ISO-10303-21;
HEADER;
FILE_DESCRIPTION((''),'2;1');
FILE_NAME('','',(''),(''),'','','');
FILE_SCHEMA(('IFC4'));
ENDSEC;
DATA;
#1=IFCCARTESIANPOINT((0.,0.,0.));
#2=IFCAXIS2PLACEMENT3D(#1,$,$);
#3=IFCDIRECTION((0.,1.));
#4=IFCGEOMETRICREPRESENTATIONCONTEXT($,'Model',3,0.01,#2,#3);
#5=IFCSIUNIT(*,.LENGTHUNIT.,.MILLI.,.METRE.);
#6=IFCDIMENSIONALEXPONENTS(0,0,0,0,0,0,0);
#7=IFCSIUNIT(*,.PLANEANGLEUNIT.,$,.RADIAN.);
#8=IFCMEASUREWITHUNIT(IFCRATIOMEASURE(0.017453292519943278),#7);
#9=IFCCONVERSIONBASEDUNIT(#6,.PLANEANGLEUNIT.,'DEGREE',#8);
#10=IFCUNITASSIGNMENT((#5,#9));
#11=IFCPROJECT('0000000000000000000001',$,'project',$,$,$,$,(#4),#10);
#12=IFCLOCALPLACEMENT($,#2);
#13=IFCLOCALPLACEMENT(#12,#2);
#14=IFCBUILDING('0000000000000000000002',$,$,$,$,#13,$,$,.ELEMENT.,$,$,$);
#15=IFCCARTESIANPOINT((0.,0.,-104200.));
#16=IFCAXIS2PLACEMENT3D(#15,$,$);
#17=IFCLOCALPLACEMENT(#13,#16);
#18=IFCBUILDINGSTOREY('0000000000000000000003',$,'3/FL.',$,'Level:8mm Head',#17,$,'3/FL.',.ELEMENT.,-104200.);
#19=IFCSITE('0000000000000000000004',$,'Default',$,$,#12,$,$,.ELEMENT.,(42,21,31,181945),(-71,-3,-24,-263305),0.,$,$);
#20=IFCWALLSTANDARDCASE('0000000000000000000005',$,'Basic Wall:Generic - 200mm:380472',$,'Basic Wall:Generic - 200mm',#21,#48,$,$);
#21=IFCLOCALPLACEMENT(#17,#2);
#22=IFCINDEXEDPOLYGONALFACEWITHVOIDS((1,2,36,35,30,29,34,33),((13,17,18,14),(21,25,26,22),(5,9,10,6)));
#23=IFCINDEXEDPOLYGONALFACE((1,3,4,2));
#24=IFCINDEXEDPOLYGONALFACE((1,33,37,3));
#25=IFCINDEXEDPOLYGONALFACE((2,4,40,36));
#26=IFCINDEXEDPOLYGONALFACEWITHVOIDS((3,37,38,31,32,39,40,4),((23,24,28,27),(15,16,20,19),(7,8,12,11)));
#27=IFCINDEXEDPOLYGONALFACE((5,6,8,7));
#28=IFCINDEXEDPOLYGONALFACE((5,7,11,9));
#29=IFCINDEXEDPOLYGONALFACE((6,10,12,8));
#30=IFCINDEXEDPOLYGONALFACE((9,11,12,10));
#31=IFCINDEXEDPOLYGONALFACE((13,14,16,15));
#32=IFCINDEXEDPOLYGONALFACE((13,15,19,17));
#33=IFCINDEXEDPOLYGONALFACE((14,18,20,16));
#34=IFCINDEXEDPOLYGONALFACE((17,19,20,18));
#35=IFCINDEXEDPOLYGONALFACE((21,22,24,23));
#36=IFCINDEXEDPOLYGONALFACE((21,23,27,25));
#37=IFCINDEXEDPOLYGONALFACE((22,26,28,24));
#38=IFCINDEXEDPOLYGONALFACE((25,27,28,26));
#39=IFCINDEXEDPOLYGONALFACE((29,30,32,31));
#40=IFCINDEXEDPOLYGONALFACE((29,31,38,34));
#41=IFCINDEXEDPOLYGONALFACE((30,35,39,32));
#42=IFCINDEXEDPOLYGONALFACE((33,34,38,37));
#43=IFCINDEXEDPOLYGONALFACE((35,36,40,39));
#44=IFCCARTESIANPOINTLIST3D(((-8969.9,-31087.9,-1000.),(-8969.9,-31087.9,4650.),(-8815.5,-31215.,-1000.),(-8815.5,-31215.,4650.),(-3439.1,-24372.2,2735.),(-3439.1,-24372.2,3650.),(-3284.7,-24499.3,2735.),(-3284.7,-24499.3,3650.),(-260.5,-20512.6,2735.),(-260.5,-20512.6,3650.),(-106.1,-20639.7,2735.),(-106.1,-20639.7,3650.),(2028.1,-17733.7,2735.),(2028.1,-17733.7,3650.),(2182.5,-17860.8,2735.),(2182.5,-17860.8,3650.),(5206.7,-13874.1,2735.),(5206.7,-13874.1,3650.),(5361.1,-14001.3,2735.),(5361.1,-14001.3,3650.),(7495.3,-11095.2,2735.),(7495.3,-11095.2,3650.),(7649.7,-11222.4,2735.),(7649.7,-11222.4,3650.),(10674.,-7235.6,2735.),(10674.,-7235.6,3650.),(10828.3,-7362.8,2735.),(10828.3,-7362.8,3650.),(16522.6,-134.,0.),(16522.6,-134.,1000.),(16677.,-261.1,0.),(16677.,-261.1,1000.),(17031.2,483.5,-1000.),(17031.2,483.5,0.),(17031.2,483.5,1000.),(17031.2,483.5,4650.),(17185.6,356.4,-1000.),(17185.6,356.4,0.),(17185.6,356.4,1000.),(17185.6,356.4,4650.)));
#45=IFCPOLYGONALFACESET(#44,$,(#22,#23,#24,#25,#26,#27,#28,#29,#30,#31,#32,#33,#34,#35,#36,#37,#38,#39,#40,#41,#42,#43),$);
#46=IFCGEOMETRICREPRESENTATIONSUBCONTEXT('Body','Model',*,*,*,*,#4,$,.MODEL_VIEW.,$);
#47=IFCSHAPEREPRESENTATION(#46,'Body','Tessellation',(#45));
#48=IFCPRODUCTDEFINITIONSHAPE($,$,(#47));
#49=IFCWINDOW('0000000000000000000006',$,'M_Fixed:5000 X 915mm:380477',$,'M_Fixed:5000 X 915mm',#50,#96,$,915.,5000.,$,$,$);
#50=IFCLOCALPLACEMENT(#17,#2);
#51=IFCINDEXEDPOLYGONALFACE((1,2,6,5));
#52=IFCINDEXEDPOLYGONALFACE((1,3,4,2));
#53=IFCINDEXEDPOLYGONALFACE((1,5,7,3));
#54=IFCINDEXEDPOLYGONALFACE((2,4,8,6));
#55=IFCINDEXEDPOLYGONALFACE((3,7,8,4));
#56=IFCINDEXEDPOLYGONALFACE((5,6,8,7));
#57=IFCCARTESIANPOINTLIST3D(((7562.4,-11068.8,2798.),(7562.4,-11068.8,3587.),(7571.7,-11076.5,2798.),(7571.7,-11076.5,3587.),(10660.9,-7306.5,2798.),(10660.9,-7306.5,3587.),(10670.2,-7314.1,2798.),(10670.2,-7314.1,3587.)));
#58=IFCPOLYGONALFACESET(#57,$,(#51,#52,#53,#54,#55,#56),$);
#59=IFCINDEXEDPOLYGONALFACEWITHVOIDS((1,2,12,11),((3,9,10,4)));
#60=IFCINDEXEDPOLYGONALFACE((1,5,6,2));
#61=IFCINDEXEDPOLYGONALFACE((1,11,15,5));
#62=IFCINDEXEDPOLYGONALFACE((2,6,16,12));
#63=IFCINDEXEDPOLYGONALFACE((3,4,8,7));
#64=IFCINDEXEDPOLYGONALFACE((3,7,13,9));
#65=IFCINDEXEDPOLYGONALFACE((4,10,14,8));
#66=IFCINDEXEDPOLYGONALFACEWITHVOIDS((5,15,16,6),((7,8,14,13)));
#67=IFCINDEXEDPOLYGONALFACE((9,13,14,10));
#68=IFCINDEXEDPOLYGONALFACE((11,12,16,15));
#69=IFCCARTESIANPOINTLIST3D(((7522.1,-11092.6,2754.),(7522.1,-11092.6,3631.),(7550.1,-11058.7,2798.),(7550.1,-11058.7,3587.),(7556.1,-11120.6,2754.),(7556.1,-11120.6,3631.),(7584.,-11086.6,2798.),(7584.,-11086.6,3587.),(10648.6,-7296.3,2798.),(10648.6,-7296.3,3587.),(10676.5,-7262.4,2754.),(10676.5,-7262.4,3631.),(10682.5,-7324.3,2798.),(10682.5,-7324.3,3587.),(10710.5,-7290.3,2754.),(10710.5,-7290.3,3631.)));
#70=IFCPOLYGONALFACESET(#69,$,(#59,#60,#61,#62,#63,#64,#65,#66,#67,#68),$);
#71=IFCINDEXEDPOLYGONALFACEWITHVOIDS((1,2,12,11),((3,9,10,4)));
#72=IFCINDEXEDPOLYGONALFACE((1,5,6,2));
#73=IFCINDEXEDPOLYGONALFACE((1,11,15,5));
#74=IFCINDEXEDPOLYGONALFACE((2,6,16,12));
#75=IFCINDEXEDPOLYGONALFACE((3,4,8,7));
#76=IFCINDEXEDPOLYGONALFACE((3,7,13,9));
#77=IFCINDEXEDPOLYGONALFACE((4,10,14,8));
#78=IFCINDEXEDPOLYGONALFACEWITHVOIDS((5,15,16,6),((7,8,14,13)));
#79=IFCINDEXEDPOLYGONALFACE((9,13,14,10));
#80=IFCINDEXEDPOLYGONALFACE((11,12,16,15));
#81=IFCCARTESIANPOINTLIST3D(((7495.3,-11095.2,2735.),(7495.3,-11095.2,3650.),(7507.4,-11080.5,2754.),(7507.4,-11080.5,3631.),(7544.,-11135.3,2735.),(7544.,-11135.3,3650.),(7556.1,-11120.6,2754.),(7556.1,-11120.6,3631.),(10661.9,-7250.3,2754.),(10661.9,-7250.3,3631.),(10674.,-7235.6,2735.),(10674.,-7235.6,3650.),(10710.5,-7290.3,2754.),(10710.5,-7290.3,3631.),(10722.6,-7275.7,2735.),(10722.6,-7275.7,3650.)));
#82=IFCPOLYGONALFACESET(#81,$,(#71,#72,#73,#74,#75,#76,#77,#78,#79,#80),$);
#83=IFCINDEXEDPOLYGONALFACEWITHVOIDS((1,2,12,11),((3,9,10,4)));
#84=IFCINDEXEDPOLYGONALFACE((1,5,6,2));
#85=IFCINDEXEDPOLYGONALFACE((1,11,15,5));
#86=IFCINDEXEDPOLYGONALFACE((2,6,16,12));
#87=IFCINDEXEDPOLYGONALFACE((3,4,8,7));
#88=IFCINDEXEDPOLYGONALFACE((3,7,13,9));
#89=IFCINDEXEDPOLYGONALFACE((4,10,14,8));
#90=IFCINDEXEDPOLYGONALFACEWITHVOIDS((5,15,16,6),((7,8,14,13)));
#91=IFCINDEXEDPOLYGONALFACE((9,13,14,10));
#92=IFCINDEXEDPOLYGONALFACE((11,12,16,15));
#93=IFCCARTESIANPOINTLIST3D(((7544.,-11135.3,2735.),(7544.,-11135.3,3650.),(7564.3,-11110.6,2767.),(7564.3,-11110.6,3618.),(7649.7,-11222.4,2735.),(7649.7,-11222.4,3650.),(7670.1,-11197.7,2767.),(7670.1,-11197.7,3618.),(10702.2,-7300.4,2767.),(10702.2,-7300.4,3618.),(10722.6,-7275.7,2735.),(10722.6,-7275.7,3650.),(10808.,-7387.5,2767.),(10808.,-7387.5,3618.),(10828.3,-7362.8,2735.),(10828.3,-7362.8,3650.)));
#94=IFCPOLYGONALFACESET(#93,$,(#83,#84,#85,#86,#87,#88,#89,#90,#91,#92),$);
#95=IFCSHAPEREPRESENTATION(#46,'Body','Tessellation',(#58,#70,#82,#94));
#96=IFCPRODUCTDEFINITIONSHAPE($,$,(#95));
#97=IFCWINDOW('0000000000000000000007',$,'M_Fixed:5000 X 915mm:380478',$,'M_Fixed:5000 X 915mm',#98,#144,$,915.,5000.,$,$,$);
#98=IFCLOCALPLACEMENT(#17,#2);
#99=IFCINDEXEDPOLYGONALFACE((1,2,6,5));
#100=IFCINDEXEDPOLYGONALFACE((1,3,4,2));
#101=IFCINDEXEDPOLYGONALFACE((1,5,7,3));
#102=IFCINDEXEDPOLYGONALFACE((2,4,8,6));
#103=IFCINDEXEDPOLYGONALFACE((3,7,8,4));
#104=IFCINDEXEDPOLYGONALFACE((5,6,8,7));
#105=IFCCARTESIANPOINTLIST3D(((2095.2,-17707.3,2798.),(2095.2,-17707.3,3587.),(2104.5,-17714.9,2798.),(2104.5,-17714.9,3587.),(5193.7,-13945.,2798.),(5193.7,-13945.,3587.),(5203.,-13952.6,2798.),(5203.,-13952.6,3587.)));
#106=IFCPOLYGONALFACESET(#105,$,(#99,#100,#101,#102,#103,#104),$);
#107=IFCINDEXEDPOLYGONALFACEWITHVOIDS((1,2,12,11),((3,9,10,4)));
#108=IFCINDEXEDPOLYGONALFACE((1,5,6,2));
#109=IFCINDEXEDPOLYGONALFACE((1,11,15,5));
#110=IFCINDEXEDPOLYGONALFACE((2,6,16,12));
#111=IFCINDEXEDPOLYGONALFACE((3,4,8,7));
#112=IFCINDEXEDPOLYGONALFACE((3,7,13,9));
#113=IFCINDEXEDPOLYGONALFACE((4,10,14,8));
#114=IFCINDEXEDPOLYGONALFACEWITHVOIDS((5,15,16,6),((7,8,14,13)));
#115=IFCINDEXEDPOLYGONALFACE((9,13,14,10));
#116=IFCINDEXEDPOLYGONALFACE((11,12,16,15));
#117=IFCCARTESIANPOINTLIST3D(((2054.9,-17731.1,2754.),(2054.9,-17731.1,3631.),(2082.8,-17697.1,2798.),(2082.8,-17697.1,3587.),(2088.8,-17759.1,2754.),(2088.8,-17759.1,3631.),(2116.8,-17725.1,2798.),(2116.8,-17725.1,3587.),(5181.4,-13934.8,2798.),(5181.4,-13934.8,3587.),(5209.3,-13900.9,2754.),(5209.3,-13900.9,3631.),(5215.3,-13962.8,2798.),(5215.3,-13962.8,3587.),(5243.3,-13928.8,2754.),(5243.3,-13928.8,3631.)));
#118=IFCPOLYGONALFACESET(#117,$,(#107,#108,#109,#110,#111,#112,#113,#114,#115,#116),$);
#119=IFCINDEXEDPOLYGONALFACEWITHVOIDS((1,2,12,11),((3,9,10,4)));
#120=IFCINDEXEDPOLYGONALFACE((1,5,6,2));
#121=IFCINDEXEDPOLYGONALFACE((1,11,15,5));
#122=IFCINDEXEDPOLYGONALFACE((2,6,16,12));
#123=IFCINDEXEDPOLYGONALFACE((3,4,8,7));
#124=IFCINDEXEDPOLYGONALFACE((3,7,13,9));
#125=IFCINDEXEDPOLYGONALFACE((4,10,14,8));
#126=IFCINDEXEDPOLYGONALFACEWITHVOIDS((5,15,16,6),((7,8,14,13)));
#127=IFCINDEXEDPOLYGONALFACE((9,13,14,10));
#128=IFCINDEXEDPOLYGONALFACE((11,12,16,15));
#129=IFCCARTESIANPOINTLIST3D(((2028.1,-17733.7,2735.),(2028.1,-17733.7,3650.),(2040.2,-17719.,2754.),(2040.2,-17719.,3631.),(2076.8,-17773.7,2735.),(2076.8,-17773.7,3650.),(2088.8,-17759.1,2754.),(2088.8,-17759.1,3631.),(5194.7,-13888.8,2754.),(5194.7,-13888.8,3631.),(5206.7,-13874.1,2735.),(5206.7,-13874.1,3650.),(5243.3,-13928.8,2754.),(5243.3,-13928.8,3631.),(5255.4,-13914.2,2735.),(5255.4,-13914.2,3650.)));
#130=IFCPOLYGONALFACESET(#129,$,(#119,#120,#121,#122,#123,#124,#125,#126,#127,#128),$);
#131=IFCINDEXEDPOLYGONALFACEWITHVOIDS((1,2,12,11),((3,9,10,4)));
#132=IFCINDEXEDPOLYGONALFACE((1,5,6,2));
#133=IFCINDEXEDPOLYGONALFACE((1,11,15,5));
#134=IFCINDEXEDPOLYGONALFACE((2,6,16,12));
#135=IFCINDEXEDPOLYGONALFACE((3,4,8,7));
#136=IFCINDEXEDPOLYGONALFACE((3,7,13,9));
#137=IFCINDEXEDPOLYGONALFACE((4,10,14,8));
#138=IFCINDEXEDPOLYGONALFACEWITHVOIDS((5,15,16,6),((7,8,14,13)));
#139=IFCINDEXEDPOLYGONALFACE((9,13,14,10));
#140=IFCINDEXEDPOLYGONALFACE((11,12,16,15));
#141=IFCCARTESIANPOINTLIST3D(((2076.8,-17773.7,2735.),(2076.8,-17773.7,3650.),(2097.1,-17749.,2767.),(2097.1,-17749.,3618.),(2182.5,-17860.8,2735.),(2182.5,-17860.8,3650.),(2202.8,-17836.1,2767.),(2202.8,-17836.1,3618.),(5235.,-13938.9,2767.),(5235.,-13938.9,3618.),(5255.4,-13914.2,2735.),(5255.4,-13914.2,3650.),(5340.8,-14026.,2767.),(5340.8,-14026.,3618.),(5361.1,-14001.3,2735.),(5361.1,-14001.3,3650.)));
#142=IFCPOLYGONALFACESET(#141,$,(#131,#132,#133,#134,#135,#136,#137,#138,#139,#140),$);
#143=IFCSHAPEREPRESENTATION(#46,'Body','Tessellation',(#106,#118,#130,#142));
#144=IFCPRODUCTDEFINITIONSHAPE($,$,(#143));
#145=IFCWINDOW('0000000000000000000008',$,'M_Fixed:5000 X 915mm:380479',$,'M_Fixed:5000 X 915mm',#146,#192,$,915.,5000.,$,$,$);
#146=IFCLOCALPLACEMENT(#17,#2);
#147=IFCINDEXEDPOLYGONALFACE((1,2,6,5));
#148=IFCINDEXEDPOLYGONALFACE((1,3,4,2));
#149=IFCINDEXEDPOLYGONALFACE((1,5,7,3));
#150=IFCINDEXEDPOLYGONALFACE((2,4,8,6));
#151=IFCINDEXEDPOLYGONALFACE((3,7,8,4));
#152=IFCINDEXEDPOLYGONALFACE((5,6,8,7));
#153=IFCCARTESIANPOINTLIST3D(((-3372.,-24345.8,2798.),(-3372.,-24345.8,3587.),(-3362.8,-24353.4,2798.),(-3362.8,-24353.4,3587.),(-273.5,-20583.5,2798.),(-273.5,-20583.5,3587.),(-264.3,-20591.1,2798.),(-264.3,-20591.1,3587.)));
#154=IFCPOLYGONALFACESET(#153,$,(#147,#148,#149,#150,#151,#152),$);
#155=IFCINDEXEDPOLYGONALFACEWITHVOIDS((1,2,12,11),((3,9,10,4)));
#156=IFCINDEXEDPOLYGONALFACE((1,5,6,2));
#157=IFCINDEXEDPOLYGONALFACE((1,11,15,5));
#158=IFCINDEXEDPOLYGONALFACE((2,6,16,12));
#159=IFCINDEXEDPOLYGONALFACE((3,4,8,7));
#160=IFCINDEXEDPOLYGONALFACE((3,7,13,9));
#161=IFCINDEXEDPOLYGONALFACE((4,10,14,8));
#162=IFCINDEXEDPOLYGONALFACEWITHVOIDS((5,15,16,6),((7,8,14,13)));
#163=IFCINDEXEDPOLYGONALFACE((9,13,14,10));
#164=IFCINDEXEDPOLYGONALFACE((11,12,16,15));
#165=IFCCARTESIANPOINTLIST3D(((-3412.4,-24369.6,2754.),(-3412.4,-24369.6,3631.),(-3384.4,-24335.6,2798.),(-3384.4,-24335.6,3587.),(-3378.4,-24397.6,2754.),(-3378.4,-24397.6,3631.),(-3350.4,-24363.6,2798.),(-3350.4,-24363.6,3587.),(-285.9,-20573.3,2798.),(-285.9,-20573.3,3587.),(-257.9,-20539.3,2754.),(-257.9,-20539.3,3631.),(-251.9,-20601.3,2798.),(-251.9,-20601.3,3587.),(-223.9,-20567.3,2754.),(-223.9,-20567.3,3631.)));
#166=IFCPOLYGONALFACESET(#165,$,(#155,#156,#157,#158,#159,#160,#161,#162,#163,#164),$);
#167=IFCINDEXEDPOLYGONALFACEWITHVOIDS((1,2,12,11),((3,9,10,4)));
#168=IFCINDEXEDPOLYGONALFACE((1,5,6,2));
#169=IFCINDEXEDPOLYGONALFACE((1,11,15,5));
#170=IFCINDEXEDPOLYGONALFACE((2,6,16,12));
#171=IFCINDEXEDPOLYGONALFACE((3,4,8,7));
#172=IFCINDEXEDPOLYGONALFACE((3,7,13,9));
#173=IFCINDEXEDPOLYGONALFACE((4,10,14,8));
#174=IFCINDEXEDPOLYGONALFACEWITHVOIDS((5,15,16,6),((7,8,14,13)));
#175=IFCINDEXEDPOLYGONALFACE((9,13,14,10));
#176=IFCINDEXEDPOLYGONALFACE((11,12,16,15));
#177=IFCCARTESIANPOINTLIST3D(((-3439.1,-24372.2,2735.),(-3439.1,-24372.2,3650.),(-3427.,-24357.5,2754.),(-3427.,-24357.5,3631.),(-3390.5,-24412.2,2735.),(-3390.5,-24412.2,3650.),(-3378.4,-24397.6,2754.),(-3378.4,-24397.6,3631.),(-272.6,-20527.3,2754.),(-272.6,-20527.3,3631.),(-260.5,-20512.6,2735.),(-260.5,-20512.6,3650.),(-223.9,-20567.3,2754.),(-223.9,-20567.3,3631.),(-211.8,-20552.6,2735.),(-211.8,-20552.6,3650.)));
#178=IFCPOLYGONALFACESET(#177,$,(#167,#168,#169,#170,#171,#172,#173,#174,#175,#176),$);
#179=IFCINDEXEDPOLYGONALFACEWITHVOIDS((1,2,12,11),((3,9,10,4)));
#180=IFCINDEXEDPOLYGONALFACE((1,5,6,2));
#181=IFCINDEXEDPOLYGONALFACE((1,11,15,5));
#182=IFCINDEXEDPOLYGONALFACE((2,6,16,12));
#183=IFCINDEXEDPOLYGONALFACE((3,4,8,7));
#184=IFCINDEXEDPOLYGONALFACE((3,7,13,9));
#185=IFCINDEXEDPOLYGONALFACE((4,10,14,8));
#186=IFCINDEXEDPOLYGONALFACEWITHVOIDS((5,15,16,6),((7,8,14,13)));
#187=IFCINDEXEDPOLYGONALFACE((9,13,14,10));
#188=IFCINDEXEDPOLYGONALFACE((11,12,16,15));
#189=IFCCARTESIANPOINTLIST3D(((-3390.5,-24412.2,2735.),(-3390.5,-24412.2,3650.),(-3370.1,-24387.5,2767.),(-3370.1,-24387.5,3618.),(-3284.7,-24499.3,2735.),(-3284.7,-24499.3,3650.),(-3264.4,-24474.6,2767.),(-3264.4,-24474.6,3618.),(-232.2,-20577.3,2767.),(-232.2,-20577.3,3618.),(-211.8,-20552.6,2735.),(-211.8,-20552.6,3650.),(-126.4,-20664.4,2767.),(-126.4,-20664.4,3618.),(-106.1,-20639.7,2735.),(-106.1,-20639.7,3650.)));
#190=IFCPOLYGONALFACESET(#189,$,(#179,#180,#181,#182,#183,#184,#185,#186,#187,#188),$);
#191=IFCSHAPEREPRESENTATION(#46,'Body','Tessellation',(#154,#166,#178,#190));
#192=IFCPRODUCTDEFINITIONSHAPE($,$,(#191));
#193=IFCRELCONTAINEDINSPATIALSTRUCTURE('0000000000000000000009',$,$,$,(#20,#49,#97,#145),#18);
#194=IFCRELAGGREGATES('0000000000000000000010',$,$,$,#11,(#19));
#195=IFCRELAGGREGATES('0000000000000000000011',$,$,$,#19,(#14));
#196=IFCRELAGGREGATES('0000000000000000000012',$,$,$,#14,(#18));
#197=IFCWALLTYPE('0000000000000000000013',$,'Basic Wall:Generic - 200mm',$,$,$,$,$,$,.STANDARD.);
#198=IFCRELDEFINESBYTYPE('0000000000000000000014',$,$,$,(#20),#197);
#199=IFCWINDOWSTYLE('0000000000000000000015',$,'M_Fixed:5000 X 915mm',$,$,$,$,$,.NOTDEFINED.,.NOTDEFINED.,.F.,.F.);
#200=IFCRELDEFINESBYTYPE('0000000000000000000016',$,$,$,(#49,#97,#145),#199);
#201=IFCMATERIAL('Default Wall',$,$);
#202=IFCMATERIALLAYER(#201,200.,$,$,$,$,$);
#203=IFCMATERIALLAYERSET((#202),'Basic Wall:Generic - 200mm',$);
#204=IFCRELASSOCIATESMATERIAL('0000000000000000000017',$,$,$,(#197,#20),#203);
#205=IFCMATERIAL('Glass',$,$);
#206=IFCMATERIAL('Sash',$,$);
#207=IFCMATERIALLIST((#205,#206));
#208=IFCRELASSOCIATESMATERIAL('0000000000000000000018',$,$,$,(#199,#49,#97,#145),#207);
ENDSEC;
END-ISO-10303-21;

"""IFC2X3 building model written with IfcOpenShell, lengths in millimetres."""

from ifc_helpers import new_model, entity, si_unit, converted_unit, direction, frame, frame_2d, origin, place, context, subcontext, project, spatial, polyline, rectangle, outline, extrude, source, transform, mapped, material, material_list, layer, layer_set, layer_usage, type_object, type_shapes, element, fill, save


model = new_model("IFC2X3")

# Units and contexts
model_context = context("Model", 3, precision=0.01, world=origin(), true_north=direction((0.0, 1.0)))
body_context = subcontext(model_context, "Body", "Model", "MODEL_VIEW")
ifc_project = project(units=[si_unit("LENGTHUNIT", "METRE", prefix="MILLI"), converted_unit("PLANEANGLEUNIT", "DEGREE", entity("IfcRatioMeasure", 0.017453292519943278), si_unit("PLANEANGLEUNIT", "RADIAN"), dimensions=[0, 0, 0, 0, 0, 0, 0])], contexts=[model_context])

# Site, building, storey
site_placement = place(None, origin())
site = spatial("IfcSite", under=ifc_project, at=site_placement, Name="Default", CompositionType="ELEMENT", RefLatitude=(42, 21, 31, 181945), RefLongitude=(-71, -3, -24, -263305), RefElevation=0.0)
building_placement = place(site_placement, origin())
building = spatial("IfcBuilding", under=site, at=building_placement, CompositionType="ELEMENT")
storey_placement = place(building_placement, frame((0.0, 0.0, -104200.0)))
storey = spatial("IfcBuildingStorey", under=building, at=storey_placement, Name="3/FL.", ObjectType="Level:8mm Head", LongName="3/FL.", CompositionType="ELEMENT", Elevation=-104200.0)

# Shared definitions
ifc_material_1 = material(Name="Default Wall")
ifc_layer = layer(ifc_material_1, 200.0)
ifc_layer_set = layer_set([ifc_layer], Name="Basic Wall:Generic - 200mm")
ifc_layer_usage = layer_usage(ifc_layer_set, "AXIS2", "NEGATIVE", 100.0)
wall_type = type_object("IfcWallType", Name="Basic Wall:Generic - 200mm", PredefinedType="STANDARD", material=ifc_layer_set)

# Wall, openings, windows
wall_1_placement = place(storey_placement, frame((17108.4, 420.0, -1000.0), z_axis=(0.0, 0.0, 1.0), x_axis=(-0.635723, -0.771917, 0.0)))
wall_1 = element("IfcWallStandardCase", 1, at=wall_1_placement, inside=storey, type_object=wall_type, material=ifc_layer_usage, Name="Basic Wall:Generic - 200mm:380472", ObjectType="Basic Wall:Generic - 200mm", context=body_context, shape_type="SweptSolid", body=[
    extrude(rectangle(XDim=40900.0, YDim=200.0, at=frame_2d((20450.0, 0.0), x_axis=(-1.0, 0.0))), origin(), (0.0, 0.0, 1.0), 5650.0),
])
opening_1_placement = place(wall_1_placement, origin())
element("IfcOpeningElement", 2, at=opening_1_placement, cuts=wall_1, ObjectType="Opening", context=body_context, shape_type="SweptSolid", body=[
    extrude(rectangle(XDim=1000.0, YDim=1012.7, at=frame_2d((0.0, 0.0), x_axis=(1.0, 0.0))), frame((293.7, -183.3, 1500.0), z_axis=(0.0, 1.0, 0.0), x_axis=(0.0, 0.0, -1.0)), (0.0, 0.0, 1.0), 1010.1),
])
opening_2_placement = place(wall_1_placement, frame((15000.0, 100.0, 3735.0)))
opening_2 = element("IfcOpeningElement", 3, at=opening_2_placement, cuts=wall_1, ObjectType="Opening", context=body_context, shape_type="SweptSolid", body=[
    extrude(rectangle(XDim=915.0, YDim=5000.0, at=frame_2d((457.5, 2500.0), x_axis=(1.0, 0.0))), frame((0.0, 0.0, 0.0), z_axis=(0.0, -1.0, 0.0), x_axis=(0.0, 0.0, 1.0)), (0.0, 0.0, 1.0), 200.0),
])
opening_3_placement = place(wall_1_placement, frame((23600.0, 100.0, 3735.0)))
opening_3 = element("IfcOpeningElement", 4, at=opening_3_placement, cuts=wall_1, ObjectType="Opening", context=body_context, shape_type="SweptSolid", body=[
    extrude(rectangle(XDim=915.0, YDim=5000.0, at=frame_2d((457.5, 2500.0), x_axis=(1.0, 0.0))), frame((0.0, 0.0, 0.0), z_axis=(0.0, -1.0, 0.0), x_axis=(0.0, 0.0, 1.0)), (0.0, 0.0, 1.0), 200.0),
])
opening_4_placement = place(wall_1_placement, frame((32200.0, 100.0, 3735.0)))
opening_4 = element("IfcOpeningElement", 5, at=opening_4_placement, cuts=wall_1, ObjectType="Opening", context=body_context, shape_type="SweptSolid", body=[
    extrude(rectangle(XDim=915.0, YDim=5000.0, at=frame_2d((457.5, 2500.0), x_axis=(1.0, 0.0))), frame((0.0, 0.0, 0.0), z_axis=(0.0, -1.0, 0.0), x_axis=(0.0, 0.0, 1.0)), (0.0, 0.0, 1.0), 200.0),
])
ifc_material_2 = material(Name="Glass")
ifc_material_3 = material(Name="Sash")
ifc_material_list = material_list([ifc_material_2, ifc_material_3])
window_style_1 = type_object("IfcWindowStyle", Name="M_Fixed:5000 X 915mm", ConstructionType="NOTDEFINED", OperationType="NOTDEFINED", ParameterTakesPrecedence=False, Sizeable=False, material=ifc_material_list)
shared_shape_1 = source(origin(), body_context, "Body", "SweptSolid", [
    extrude(rectangle(XDim=12.0, YDim=4874.0, at=frame_2d((0.0, 0.0), x_axis=(1.0, 0.0))), frame((2500.0, 159.0, 63.0), z_axis=(0.0, 0.0, 1.0), x_axis=(0.0, -1.0, 0.0)), (0.0, 0.0, 1.0), 789.0),
    extrude(outline(polyline([(-2481.0, -438.5), (2481.0, -438.5), (2481.0, 438.5), (-2481.0, 438.5), (-2481.0, -438.5)]), holes=[polyline([(-2437.0, -394.5), (-2437.0, 394.5), (2437.0, 394.5), (2437.0, -394.5), (-2437.0, -394.5)])]), frame((2500.0, 137.0, 457.5), z_axis=(0.0, 1.0, 0.0), x_axis=(1.0, 0.0, 0.0)), (0.0, 0.0, 1.0), 44.0),
    extrude(outline(polyline([(-2500.0, -457.5), (2500.0, -457.5), (2500.0, 457.5), (-2500.0, 457.5), (-2500.0, -457.5)]), holes=[polyline([(-2481.0, -438.5), (-2481.0, 438.5), (2481.0, 438.5), (2481.0, -438.5), (-2481.0, -438.5)])]), frame((2500.0, 137.0, 457.5), z_axis=(0.0, 1.0, 0.0), x_axis=(1.0, 0.0, 0.0)), (0.0, 0.0, 1.0), 63.0),
    extrude(outline(polyline([(-2500.0, -457.5), (2500.0, -457.5), (2500.0, 457.5), (-2500.0, 457.5), (-2500.0, -457.5)]), holes=[polyline([(-2468.0, -425.5), (-2468.0, 425.5), (2468.0, 425.5), (2468.0, -425.5), (-2468.0, -425.5)])]), frame((2500.0, 0.0, 457.5), z_axis=(0.0, 1.0, 0.0), x_axis=(1.0, 0.0, 0.0)), (0.0, 0.0, 1.0), 137.0),
])
type_shapes(window_style_1, [shared_shape_1])
window_1_placement = place(opening_2_placement, frame((0.0, 0.0, 0.0), z_axis=(0.0, 0.0, 1.0), x_axis=(-1.0, 0.0, 0.0)))
window_1 = element("IfcWindow", 6, at=window_1_placement, inside=storey, type_object=window_style_1, material=ifc_material_list, Name="M_Fixed:5000 X 915mm:380477", ObjectType="M_Fixed:5000 X 915mm", OverallHeight=915.0, OverallWidth=5000.0, context=body_context, shape_type="MappedRepresentation", body=[
    mapped(shared_shape_1, transform((0.0, 0.0, 0.0), scale=1.0)),
])
fill(opening_2, window_1)
window_2_placement = place(opening_3_placement, frame((0.0, 0.0, 0.0), z_axis=(0.0, 0.0, 1.0), x_axis=(-1.0, 0.0, 0.0)))
window_2 = element("IfcWindow", 7, at=window_2_placement, inside=storey, type_object=window_style_1, material=ifc_material_list, Name="M_Fixed:5000 X 915mm:380478", ObjectType="M_Fixed:5000 X 915mm", OverallHeight=915.0, OverallWidth=5000.0, context=body_context, shape_type="MappedRepresentation", body=[
    mapped(shared_shape_1, transform((0.0, 0.0, 0.0), scale=1.0)),
])
fill(opening_3, window_2)
window_3_placement = place(opening_4_placement, frame((0.0, 0.0, 0.0), z_axis=(0.0, 0.0, 1.0), x_axis=(-1.0, 0.0, 0.0)))
window_3 = element("IfcWindow", 8, at=window_3_placement, inside=storey, type_object=window_style_1, material=ifc_material_list, Name="M_Fixed:5000 X 915mm:380479", ObjectType="M_Fixed:5000 X 915mm", OverallHeight=915.0, OverallWidth=5000.0, context=body_context, shape_type="MappedRepresentation", body=[
    mapped(shared_shape_1, transform((0.0, 0.0, 0.0), scale=1.0)),
])
fill(opening_4, window_3)

save(model, "model.ifc")
